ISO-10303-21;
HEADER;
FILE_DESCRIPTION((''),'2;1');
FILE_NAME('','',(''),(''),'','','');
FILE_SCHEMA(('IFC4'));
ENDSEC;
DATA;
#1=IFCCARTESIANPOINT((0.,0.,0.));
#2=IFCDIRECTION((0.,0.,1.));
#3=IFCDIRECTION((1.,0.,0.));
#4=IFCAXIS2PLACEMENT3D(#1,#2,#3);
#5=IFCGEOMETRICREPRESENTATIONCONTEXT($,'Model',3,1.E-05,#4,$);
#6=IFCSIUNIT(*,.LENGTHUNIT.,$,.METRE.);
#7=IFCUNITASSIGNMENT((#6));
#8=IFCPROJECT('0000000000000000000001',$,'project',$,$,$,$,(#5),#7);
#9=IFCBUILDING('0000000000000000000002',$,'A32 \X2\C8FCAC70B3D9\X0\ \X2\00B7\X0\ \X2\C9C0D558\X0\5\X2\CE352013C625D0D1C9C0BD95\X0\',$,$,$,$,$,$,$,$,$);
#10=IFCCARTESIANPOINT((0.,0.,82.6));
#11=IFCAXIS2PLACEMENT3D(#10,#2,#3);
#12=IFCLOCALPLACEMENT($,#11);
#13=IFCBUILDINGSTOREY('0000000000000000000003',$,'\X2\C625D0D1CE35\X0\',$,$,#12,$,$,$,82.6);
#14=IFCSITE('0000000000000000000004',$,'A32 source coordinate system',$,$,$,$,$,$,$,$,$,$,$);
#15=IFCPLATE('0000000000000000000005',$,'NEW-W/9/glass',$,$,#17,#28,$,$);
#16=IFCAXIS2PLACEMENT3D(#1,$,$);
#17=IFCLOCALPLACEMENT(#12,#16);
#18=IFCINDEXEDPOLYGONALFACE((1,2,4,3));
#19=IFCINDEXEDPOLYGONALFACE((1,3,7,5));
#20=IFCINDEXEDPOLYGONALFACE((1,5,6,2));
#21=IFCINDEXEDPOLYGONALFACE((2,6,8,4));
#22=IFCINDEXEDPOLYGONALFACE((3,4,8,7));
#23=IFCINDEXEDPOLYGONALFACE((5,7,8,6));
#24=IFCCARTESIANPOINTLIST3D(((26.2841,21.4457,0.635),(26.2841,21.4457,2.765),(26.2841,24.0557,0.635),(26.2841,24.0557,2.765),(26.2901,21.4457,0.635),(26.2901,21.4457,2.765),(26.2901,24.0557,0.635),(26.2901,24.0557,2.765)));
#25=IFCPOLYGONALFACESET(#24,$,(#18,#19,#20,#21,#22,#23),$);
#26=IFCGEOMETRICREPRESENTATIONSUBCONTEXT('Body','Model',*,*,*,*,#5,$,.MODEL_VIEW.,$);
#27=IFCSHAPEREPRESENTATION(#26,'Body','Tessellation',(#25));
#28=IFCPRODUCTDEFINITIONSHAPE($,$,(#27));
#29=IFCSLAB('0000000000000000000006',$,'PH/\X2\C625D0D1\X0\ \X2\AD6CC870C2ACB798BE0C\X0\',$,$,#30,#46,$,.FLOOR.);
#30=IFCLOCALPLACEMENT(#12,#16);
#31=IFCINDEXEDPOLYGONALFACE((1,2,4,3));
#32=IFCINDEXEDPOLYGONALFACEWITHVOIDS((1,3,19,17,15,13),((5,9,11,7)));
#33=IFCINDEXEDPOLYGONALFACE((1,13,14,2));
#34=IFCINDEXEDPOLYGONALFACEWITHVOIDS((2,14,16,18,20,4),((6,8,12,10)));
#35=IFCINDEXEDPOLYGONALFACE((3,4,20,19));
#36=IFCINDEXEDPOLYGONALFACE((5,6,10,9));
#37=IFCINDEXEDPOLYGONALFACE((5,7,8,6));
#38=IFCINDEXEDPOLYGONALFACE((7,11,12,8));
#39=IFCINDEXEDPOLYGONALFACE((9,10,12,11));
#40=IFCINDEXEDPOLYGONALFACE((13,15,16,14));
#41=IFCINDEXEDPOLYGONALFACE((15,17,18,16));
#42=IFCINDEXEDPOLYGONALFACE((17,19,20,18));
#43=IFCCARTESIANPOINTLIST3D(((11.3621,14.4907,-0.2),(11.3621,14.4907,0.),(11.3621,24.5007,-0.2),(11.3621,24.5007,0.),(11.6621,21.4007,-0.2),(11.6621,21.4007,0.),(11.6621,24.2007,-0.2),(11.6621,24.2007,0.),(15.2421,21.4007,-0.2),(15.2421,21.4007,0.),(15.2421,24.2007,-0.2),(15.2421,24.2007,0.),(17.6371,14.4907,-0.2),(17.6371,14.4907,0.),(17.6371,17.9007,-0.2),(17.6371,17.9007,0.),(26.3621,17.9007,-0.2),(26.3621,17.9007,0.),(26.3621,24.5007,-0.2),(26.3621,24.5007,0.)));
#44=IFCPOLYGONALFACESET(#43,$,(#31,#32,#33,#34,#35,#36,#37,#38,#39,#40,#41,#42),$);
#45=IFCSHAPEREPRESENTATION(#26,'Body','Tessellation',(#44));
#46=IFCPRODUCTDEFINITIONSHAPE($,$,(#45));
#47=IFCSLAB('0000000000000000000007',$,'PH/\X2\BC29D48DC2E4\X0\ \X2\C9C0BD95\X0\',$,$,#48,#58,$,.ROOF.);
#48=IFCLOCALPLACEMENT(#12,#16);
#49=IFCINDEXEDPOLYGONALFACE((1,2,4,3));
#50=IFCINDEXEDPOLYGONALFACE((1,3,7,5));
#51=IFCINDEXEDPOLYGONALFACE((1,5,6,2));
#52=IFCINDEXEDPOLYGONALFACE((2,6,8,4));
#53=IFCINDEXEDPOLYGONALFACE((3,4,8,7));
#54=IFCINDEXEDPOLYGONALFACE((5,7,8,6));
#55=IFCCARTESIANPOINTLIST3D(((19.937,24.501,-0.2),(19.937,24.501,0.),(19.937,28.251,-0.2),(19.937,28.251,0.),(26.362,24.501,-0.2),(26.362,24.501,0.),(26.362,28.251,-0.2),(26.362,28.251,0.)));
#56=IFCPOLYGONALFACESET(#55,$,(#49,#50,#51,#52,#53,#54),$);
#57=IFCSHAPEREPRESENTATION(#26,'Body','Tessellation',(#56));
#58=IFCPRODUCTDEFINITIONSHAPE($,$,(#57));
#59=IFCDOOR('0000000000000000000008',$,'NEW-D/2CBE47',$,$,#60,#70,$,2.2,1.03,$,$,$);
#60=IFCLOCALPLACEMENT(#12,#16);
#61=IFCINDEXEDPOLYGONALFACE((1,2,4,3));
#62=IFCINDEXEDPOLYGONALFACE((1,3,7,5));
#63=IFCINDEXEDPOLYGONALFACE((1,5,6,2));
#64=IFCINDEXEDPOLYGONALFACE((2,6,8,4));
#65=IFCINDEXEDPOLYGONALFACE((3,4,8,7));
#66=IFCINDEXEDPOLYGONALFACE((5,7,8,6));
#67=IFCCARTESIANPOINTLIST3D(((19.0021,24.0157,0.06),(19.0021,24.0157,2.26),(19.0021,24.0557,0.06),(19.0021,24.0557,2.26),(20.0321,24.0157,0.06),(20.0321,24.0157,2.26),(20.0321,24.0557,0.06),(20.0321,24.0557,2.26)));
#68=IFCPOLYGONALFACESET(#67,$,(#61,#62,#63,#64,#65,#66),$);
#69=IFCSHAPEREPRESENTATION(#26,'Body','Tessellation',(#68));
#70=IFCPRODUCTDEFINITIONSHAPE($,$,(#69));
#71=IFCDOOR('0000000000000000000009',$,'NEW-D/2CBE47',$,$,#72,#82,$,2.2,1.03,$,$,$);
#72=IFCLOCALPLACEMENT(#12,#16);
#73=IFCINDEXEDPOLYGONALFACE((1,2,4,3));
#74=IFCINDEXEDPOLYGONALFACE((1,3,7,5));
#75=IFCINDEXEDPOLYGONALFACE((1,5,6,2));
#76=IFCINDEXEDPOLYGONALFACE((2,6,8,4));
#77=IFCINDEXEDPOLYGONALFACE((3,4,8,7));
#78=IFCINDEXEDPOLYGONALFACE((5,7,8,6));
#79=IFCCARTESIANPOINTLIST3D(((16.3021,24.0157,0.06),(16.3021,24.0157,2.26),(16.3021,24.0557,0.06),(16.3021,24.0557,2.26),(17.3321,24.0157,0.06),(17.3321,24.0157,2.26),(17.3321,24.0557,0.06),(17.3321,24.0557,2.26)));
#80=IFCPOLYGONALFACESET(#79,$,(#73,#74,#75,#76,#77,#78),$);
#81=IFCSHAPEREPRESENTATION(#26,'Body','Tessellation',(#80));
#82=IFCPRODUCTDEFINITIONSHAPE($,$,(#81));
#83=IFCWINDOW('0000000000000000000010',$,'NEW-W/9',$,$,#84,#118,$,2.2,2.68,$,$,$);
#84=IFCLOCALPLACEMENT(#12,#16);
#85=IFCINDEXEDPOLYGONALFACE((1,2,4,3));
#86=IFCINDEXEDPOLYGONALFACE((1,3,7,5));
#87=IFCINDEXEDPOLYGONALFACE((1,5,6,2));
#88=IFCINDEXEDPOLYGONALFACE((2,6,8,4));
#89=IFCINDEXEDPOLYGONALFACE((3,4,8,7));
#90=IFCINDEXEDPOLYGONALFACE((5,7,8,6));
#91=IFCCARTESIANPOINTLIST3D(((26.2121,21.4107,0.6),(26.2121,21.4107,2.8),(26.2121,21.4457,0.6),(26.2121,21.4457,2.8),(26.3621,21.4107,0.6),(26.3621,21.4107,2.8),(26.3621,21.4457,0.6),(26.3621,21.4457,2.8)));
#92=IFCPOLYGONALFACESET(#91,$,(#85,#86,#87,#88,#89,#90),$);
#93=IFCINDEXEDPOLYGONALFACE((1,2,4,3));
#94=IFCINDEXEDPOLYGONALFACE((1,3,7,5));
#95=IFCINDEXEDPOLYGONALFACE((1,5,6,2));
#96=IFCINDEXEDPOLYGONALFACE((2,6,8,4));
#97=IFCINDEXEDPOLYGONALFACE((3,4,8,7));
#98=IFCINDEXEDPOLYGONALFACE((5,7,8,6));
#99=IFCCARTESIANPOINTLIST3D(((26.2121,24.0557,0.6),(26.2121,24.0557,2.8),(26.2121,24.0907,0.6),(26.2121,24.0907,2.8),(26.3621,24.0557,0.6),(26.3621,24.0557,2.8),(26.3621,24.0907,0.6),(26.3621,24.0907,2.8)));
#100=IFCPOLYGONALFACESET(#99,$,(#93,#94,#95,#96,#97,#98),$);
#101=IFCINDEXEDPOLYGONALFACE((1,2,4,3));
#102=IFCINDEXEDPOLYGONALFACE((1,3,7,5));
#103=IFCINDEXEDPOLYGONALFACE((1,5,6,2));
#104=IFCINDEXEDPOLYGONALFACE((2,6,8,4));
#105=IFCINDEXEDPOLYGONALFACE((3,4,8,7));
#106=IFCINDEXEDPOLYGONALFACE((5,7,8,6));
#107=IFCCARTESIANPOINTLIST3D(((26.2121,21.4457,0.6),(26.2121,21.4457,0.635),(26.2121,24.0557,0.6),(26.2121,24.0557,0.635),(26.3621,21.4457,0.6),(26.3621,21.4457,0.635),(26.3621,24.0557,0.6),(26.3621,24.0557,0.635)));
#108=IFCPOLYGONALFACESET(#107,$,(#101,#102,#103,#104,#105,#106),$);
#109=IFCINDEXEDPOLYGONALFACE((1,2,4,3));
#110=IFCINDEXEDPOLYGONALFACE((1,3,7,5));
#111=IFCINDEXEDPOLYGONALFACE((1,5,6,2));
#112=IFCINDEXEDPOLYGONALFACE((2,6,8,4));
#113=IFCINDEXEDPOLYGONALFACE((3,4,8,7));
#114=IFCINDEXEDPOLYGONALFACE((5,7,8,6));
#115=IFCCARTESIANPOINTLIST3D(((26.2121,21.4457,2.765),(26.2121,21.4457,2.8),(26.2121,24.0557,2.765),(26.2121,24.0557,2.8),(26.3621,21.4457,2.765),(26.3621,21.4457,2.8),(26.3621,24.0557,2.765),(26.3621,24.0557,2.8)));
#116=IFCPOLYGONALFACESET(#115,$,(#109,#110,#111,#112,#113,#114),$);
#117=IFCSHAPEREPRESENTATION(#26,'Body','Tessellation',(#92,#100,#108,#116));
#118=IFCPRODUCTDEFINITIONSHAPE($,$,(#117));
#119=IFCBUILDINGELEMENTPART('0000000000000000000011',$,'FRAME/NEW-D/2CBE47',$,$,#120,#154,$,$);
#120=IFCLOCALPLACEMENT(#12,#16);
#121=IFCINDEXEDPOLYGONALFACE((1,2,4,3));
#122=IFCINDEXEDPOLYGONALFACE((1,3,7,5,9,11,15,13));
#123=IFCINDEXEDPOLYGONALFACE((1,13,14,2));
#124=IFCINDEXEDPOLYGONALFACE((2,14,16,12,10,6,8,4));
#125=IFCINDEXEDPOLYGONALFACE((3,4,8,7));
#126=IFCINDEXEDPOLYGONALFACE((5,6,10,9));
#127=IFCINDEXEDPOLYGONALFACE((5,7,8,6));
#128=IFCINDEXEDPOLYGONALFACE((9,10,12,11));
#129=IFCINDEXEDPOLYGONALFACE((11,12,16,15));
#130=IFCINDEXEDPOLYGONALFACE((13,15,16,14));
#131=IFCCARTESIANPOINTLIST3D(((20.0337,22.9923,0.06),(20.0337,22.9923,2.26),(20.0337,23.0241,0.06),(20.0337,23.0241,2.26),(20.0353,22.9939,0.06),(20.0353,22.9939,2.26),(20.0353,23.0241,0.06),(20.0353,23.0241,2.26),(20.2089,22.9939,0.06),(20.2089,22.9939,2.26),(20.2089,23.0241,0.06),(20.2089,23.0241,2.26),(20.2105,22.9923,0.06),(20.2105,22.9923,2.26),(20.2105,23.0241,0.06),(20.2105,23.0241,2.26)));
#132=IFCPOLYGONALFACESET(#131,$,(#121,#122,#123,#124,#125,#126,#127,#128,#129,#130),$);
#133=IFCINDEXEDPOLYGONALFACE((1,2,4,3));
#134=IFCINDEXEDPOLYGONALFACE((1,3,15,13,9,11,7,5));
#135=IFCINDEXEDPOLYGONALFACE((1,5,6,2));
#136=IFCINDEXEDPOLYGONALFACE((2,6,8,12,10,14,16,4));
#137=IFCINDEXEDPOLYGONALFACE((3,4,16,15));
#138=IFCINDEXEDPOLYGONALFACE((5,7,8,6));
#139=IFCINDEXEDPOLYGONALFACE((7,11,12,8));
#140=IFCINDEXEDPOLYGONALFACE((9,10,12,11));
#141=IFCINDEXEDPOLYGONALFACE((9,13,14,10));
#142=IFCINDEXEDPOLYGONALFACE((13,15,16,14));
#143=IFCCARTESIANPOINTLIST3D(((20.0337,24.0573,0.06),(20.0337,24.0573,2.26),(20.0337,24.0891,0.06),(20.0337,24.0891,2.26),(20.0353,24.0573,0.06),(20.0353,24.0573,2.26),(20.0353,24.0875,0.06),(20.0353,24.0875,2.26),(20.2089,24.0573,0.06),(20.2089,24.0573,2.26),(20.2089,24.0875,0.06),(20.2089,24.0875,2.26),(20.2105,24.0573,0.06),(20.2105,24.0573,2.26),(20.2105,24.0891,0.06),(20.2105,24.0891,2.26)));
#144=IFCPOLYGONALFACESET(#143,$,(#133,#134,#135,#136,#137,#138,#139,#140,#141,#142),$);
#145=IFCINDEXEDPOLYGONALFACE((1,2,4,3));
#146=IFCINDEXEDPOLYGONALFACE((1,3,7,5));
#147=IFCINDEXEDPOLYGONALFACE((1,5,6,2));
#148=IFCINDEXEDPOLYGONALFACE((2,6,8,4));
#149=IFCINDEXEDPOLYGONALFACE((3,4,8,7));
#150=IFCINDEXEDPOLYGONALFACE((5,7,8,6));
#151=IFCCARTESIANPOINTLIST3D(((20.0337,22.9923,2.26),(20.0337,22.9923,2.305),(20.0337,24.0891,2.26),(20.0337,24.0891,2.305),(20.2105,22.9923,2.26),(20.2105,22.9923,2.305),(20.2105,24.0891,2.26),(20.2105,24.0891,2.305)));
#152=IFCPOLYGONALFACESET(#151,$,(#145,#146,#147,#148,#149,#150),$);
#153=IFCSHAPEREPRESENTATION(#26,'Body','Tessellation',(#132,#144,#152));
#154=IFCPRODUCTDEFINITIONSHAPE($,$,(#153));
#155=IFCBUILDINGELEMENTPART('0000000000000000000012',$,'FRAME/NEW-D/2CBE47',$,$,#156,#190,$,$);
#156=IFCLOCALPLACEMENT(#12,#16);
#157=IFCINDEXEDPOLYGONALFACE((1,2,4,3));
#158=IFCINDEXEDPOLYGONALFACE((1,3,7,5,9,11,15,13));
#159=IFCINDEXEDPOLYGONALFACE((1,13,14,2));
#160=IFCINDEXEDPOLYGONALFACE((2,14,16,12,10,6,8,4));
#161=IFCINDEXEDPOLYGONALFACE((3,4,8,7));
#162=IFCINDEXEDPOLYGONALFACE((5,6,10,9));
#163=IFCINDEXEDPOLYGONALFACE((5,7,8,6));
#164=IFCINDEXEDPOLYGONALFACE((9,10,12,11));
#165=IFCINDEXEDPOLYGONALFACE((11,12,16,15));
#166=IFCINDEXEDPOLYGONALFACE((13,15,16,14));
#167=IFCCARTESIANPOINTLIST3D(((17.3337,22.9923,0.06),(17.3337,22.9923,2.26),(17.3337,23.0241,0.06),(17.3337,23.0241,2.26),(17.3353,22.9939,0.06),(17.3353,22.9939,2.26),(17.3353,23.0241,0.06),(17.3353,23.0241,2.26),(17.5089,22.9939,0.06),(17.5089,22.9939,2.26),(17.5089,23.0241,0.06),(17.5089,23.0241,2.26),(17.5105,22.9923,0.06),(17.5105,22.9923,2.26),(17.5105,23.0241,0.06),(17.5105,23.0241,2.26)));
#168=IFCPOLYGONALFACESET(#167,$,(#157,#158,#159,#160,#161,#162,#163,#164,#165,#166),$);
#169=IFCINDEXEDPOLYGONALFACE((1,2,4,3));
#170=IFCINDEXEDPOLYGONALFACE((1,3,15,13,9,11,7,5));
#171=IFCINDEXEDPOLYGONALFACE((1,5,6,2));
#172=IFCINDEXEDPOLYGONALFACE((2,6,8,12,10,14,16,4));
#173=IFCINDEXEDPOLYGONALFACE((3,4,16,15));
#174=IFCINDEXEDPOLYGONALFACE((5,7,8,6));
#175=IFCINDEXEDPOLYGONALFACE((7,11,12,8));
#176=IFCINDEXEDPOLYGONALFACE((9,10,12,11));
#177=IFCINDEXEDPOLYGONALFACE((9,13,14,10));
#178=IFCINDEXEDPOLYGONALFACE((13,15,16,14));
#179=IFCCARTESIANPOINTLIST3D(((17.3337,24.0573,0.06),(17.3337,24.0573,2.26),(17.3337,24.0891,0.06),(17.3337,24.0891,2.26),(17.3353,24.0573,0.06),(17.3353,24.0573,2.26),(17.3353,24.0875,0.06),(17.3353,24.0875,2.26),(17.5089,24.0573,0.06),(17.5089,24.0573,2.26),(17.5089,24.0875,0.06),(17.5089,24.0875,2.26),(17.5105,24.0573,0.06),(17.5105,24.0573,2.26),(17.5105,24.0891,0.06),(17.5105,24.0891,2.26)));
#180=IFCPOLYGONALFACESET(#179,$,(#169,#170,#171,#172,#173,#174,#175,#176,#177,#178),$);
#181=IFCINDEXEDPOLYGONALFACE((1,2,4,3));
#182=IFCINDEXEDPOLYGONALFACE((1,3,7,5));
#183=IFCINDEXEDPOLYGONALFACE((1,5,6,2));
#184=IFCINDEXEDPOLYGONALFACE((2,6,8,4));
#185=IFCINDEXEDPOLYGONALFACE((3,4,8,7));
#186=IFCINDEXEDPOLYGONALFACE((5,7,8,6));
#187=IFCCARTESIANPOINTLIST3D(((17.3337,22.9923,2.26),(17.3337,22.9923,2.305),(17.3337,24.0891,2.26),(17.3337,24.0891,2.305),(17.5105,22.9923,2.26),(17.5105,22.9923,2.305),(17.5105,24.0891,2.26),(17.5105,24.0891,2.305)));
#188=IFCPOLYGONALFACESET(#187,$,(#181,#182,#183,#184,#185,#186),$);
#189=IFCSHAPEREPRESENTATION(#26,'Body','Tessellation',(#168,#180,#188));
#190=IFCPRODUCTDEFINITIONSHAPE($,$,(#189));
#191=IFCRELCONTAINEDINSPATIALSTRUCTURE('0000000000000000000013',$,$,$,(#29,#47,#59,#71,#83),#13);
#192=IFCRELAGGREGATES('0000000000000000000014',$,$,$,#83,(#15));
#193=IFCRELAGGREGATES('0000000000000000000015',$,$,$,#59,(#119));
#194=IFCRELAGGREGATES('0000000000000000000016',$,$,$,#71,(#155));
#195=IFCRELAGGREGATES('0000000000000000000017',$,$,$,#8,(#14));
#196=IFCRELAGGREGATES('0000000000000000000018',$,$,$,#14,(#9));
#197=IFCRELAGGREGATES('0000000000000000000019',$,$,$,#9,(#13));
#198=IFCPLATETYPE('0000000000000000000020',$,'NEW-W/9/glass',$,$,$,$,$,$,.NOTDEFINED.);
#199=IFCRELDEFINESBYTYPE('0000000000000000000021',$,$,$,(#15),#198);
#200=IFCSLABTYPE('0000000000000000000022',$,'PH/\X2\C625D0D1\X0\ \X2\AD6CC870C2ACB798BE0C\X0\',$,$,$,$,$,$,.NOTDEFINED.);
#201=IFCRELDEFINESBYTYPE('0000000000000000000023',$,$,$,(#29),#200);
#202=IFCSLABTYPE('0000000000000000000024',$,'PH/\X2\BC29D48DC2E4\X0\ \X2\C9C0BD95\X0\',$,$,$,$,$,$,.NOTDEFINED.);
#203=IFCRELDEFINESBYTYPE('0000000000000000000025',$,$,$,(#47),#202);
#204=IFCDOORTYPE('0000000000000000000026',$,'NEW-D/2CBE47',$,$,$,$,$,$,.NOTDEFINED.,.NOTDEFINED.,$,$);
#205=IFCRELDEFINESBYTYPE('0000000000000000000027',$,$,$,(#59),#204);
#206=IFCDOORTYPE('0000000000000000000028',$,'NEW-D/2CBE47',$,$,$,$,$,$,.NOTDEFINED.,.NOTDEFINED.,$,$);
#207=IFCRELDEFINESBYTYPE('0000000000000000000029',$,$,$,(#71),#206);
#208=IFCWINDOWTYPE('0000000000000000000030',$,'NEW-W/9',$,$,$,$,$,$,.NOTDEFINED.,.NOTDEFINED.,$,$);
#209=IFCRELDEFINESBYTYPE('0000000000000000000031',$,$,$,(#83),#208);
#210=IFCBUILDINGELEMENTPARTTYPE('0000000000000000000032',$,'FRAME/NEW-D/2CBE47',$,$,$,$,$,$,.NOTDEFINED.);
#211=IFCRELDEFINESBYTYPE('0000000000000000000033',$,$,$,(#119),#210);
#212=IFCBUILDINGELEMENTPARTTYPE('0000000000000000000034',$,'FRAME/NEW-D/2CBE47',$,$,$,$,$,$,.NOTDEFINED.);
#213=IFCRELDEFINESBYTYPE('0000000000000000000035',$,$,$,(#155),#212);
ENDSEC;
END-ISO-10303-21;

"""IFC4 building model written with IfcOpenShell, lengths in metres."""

from ifc_helpers import new_model, si_unit, frame, origin, origin_with_axes, place, context, subcontext, project, spatial, polyline, outline, extrude, source, transform, mapped, type_object, type_shapes, element, aggregate, save


model = new_model("IFC4")

# Units and contexts
model_context = context("Model", 3, precision=1e-05, world=origin_with_axes())
body_context = subcontext(model_context, "Body", "Model", "MODEL_VIEW")
ifc_project = project(units=[si_unit("LENGTHUNIT", "METRE")], contexts=[model_context])

# Plate
storey_placement = place(None, frame((0.0, 0.0, 82.6), z_axis=(0.0, 0.0, 1.0), x_axis=(1.0, 0.0, 0.0)))
plate_type_1 = type_object("IfcPlateType", Name="NEW-W/9/glass", PredefinedType="NOTDEFINED")
shared_shape_1 = source(origin(), body_context, "Body", "SweptSolid", [
    extrude(outline(polyline([(26.2901, 21.4457), (26.2841, 21.4457), (26.2841, 24.0557), (26.2901, 24.0557), (26.2901, 21.4457)])), frame((0.0, 0.0, 0.635)), (0.0, 0.0, 1.0), 2.13),
])
type_shapes(plate_type_1, [shared_shape_1])
window_1_placement = place(storey_placement, origin_with_axes())
plate_1_placement = place(window_1_placement, origin_with_axes())
plate_1 = element("IfcPlate", 1, at=plate_1_placement, type_object=plate_type_1, Name="NEW-W/9/glass", context=body_context, shape_type="MappedRepresentation", body=[
    mapped(shared_shape_1, transform((0.0, 0.0, 0.0), scale=1.0)),
])

# Site, building, storey
site = spatial("IfcSite", under=ifc_project, Name="A32 source coordinate system")
building = spatial("IfcBuilding", under=site, Name="A32 주거동 · 지하5층–옥탑지붕")
storey = spatial("IfcBuildingStorey", under=building, at=storey_placement, Name="옥탑층", Elevation=82.6)

# Slabs
slab_type_1 = type_object("IfcSlabType", Name="PH/옥탑 구조슬래브", PredefinedType="NOTDEFINED")
shared_shape_2 = source(origin(), body_context, "Body", "SweptSolid", [
    extrude(outline(polyline([(26.3621, 17.9007), (17.6371, 17.9007), (17.6371, 14.4907), (11.3621, 14.4907), (11.3621, 24.5007), (26.3621, 24.5007), (26.3621, 17.9007)]), holes=[polyline([(15.2421, 24.2007), (11.6621, 24.2007), (11.6621, 21.4007), (15.2421, 21.4007), (15.2421, 24.2007)])]), frame((0.0, 0.0, -0.2)), (0.0, 0.0, 1.0), 0.2),
])
type_shapes(slab_type_1, [shared_shape_2])
slab_1_placement = place(storey_placement, origin_with_axes())
element("IfcSlab", 2, at=slab_1_placement, inside=storey, type_object=slab_type_1, Name="PH/옥탑 구조슬래브", PredefinedType="FLOOR", context=body_context, shape_type="MappedRepresentation", body=[
    mapped(shared_shape_2, transform((0.0, 0.0, 0.0), scale=1.0)),
])
slab_type_2 = type_object("IfcSlabType", Name="PH/방풍실 지붕", PredefinedType="NOTDEFINED")
shared_shape_3 = source(origin(), body_context, "Body", "SweptSolid", [
    extrude(outline(polyline([(26.362, 24.501), (19.937, 24.501), (19.937, 28.251), (26.362, 28.251), (26.362, 24.501)])), frame((0.0, 0.0, -0.2)), (0.0, 0.0, 1.0), 0.2),
])
type_shapes(slab_type_2, [shared_shape_3])
slab_2_placement = place(storey_placement, origin_with_axes())
element("IfcSlab", 3, at=slab_2_placement, inside=storey, type_object=slab_type_2, Name="PH/방풍실 지붕", PredefinedType="ROOF", context=body_context, shape_type="MappedRepresentation", body=[
    mapped(shared_shape_3, transform((0.0, 0.0, 0.0), scale=1.0)),
])

# Doors
door_type_1 = type_object("IfcDoorType", Name="NEW-D/2CBE47", OperationType="NOTDEFINED", PredefinedType="NOTDEFINED")
shared_shape_4 = source(origin(), body_context, "Body", "SweptSolid", [
    extrude(outline(polyline([(20.0321, 24.0557), (20.0321, 24.0157), (19.0021, 24.0157), (19.0021, 24.0557), (20.0321, 24.0557)])), frame((0.0, 0.0, 0.06)), (0.0, 0.0, 1.0), 2.2),
])
type_shapes(door_type_1, [shared_shape_4])
door_1_placement = place(storey_placement, origin_with_axes())
door_1 = element("IfcDoor", 4, at=door_1_placement, inside=storey, type_object=door_type_1, Name="NEW-D/2CBE47", OverallHeight=2.2, OverallWidth=1.03, context=body_context, shape_type="MappedRepresentation", body=[
    mapped(shared_shape_4, transform((0.0, 0.0, 0.0), scale=1.0)),
])
door_type_2 = type_object("IfcDoorType", Name="NEW-D/2CBE47", OperationType="NOTDEFINED", PredefinedType="NOTDEFINED")
shared_shape_5 = source(origin(), body_context, "Body", "SweptSolid", [
    extrude(outline(polyline([(17.3321, 24.0557), (17.3321, 24.0157), (16.3021, 24.0157), (16.3021, 24.0557), (17.3321, 24.0557)])), frame((0.0, 0.0, 0.06)), (0.0, 0.0, 1.0), 2.2),
])
type_shapes(door_type_2, [shared_shape_5])
door_2_placement = place(storey_placement, origin_with_axes())
door_2 = element("IfcDoor", 5, at=door_2_placement, inside=storey, type_object=door_type_2, Name="NEW-D/2CBE47", OverallHeight=2.2, OverallWidth=1.03, context=body_context, shape_type="MappedRepresentation", body=[
    mapped(shared_shape_5, transform((0.0, 0.0, 0.0), scale=1.0)),
])

# Window
window_type_1 = type_object("IfcWindowType", Name="NEW-W/9", PartitioningType="NOTDEFINED", PredefinedType="NOTDEFINED")
shared_shape_6 = source(origin(), body_context, "Body", "SweptSolid", [
    extrude(outline(polyline([(26.2121, 21.4107), (26.2121, 21.4457), (26.3621, 21.4457), (26.3621, 21.4107), (26.2121, 21.4107)])), frame((0.0, 0.0, 0.6)), (0.0, 0.0, 1.0), 2.2),
    extrude(outline(polyline([(26.2121, 24.0557), (26.2121, 24.0907), (26.3621, 24.0907), (26.3621, 24.0557), (26.2121, 24.0557)])), frame((0.0, 0.0, 0.6)), (0.0, 0.0, 1.0), 2.2),
    extrude(outline(polyline([(26.3621, 21.4457), (26.3621, 24.0557), (26.2121, 24.0557), (26.2121, 21.4457), (26.3621, 21.4457)])), frame((0.0, 0.0, 0.6)), (0.0, 0.0, 1.0), 0.035),
    extrude(outline(polyline([(26.3621, 21.4457), (26.3621, 24.0557), (26.2121, 24.0557), (26.2121, 21.4457), (26.3621, 21.4457)])), frame((0.0, 0.0, 2.765)), (0.0, 0.0, 1.0), 0.035),
])
type_shapes(window_type_1, [shared_shape_6])
window_1 = element("IfcWindow", 6, at=window_1_placement, inside=storey, type_object=window_type_1, Name="NEW-W/9", OverallHeight=2.2, OverallWidth=2.68, context=body_context, shape_type="MappedRepresentation", body=[
    mapped(shared_shape_6, transform((0.0, 0.0, 0.0), scale=1.0)),
])
aggregate(window_1, [plate_1])

# Building element parts
building_element_part_type_1 = type_object("IfcBuildingElementPartType", Name="FRAME/NEW-D/2CBE47", PredefinedType="NOTDEFINED")
shared_shape_7 = source(origin(), body_context, "Body", "SweptSolid", [
    extrude(outline(polyline([(20.0353, 22.9939), (20.2089, 22.9939), (20.2089, 23.0241), (20.2105, 23.0241), (20.2105, 22.9923), (20.0337, 22.9923), (20.0337, 23.0241), (20.0353, 23.0241), (20.0353, 22.9939)])), frame((0.0, 0.0, 0.06)), (0.0, 0.0, 1.0), 2.2),
    extrude(outline(polyline([(20.2105, 24.0891), (20.2105, 24.0573), (20.2089, 24.0573), (20.2089, 24.0875), (20.0353, 24.0875), (20.0353, 24.0573), (20.0337, 24.0573), (20.0337, 24.0891), (20.2105, 24.0891)])), frame((0.0, 0.0, 0.06)), (0.0, 0.0, 1.0), 2.2),
    extrude(outline(polyline([(20.2105, 22.9923), (20.2105, 24.0891), (20.0337, 24.0891), (20.0337, 22.9923), (20.2105, 22.9923)])), frame((0.0, 0.0, 2.26)), (0.0, 0.0, 1.0), 0.045),
])
type_shapes(building_element_part_type_1, [shared_shape_7])
building_element_part_1_placement = place(door_1_placement, origin_with_axes())
building_element_part_1 = element("IfcBuildingElementPart", 7, at=building_element_part_1_placement, type_object=building_element_part_type_1, Name="FRAME/NEW-D/2CBE47", context=body_context, shape_type="MappedRepresentation", body=[
    mapped(shared_shape_7, transform((0.0, 0.0, 0.0), scale=1.0)),
])
aggregate(door_1, [building_element_part_1])
building_element_part_type_2 = type_object("IfcBuildingElementPartType", Name="FRAME/NEW-D/2CBE47", PredefinedType="NOTDEFINED")
shared_shape_8 = source(origin(), body_context, "Body", "SweptSolid", [
    extrude(outline(polyline([(17.3353, 22.9939), (17.5089, 22.9939), (17.5089, 23.0241), (17.5105, 23.0241), (17.5105, 22.9923), (17.3337, 22.9923), (17.3337, 23.0241), (17.3353, 23.0241), (17.3353, 22.9939)])), frame((0.0, 0.0, 0.06)), (0.0, 0.0, 1.0), 2.2),
    extrude(outline(polyline([(17.5105, 24.0891), (17.5105, 24.0573), (17.5089, 24.0573), (17.5089, 24.0875), (17.3353, 24.0875), (17.3353, 24.0573), (17.3337, 24.0573), (17.3337, 24.0891), (17.5105, 24.0891)])), frame((0.0, 0.0, 0.06)), (0.0, 0.0, 1.0), 2.2),
    extrude(outline(polyline([(17.5105, 22.9923), (17.5105, 24.0891), (17.3337, 24.0891), (17.3337, 22.9923), (17.5105, 22.9923)])), frame((0.0, 0.0, 2.26)), (0.0, 0.0, 1.0), 0.045),
])
type_shapes(building_element_part_type_2, [shared_shape_8])
building_element_part_2_placement = place(door_2_placement, origin_with_axes())
building_element_part_2 = element("IfcBuildingElementPart", 8, at=building_element_part_2_placement, type_object=building_element_part_type_2, Name="FRAME/NEW-D/2CBE47", context=body_context, shape_type="MappedRepresentation", body=[
    mapped(shared_shape_8, transform((0.0, 0.0, 0.0), scale=1.0)),
])
aggregate(door_2, [building_element_part_2])

save(model, "model.ifc")
